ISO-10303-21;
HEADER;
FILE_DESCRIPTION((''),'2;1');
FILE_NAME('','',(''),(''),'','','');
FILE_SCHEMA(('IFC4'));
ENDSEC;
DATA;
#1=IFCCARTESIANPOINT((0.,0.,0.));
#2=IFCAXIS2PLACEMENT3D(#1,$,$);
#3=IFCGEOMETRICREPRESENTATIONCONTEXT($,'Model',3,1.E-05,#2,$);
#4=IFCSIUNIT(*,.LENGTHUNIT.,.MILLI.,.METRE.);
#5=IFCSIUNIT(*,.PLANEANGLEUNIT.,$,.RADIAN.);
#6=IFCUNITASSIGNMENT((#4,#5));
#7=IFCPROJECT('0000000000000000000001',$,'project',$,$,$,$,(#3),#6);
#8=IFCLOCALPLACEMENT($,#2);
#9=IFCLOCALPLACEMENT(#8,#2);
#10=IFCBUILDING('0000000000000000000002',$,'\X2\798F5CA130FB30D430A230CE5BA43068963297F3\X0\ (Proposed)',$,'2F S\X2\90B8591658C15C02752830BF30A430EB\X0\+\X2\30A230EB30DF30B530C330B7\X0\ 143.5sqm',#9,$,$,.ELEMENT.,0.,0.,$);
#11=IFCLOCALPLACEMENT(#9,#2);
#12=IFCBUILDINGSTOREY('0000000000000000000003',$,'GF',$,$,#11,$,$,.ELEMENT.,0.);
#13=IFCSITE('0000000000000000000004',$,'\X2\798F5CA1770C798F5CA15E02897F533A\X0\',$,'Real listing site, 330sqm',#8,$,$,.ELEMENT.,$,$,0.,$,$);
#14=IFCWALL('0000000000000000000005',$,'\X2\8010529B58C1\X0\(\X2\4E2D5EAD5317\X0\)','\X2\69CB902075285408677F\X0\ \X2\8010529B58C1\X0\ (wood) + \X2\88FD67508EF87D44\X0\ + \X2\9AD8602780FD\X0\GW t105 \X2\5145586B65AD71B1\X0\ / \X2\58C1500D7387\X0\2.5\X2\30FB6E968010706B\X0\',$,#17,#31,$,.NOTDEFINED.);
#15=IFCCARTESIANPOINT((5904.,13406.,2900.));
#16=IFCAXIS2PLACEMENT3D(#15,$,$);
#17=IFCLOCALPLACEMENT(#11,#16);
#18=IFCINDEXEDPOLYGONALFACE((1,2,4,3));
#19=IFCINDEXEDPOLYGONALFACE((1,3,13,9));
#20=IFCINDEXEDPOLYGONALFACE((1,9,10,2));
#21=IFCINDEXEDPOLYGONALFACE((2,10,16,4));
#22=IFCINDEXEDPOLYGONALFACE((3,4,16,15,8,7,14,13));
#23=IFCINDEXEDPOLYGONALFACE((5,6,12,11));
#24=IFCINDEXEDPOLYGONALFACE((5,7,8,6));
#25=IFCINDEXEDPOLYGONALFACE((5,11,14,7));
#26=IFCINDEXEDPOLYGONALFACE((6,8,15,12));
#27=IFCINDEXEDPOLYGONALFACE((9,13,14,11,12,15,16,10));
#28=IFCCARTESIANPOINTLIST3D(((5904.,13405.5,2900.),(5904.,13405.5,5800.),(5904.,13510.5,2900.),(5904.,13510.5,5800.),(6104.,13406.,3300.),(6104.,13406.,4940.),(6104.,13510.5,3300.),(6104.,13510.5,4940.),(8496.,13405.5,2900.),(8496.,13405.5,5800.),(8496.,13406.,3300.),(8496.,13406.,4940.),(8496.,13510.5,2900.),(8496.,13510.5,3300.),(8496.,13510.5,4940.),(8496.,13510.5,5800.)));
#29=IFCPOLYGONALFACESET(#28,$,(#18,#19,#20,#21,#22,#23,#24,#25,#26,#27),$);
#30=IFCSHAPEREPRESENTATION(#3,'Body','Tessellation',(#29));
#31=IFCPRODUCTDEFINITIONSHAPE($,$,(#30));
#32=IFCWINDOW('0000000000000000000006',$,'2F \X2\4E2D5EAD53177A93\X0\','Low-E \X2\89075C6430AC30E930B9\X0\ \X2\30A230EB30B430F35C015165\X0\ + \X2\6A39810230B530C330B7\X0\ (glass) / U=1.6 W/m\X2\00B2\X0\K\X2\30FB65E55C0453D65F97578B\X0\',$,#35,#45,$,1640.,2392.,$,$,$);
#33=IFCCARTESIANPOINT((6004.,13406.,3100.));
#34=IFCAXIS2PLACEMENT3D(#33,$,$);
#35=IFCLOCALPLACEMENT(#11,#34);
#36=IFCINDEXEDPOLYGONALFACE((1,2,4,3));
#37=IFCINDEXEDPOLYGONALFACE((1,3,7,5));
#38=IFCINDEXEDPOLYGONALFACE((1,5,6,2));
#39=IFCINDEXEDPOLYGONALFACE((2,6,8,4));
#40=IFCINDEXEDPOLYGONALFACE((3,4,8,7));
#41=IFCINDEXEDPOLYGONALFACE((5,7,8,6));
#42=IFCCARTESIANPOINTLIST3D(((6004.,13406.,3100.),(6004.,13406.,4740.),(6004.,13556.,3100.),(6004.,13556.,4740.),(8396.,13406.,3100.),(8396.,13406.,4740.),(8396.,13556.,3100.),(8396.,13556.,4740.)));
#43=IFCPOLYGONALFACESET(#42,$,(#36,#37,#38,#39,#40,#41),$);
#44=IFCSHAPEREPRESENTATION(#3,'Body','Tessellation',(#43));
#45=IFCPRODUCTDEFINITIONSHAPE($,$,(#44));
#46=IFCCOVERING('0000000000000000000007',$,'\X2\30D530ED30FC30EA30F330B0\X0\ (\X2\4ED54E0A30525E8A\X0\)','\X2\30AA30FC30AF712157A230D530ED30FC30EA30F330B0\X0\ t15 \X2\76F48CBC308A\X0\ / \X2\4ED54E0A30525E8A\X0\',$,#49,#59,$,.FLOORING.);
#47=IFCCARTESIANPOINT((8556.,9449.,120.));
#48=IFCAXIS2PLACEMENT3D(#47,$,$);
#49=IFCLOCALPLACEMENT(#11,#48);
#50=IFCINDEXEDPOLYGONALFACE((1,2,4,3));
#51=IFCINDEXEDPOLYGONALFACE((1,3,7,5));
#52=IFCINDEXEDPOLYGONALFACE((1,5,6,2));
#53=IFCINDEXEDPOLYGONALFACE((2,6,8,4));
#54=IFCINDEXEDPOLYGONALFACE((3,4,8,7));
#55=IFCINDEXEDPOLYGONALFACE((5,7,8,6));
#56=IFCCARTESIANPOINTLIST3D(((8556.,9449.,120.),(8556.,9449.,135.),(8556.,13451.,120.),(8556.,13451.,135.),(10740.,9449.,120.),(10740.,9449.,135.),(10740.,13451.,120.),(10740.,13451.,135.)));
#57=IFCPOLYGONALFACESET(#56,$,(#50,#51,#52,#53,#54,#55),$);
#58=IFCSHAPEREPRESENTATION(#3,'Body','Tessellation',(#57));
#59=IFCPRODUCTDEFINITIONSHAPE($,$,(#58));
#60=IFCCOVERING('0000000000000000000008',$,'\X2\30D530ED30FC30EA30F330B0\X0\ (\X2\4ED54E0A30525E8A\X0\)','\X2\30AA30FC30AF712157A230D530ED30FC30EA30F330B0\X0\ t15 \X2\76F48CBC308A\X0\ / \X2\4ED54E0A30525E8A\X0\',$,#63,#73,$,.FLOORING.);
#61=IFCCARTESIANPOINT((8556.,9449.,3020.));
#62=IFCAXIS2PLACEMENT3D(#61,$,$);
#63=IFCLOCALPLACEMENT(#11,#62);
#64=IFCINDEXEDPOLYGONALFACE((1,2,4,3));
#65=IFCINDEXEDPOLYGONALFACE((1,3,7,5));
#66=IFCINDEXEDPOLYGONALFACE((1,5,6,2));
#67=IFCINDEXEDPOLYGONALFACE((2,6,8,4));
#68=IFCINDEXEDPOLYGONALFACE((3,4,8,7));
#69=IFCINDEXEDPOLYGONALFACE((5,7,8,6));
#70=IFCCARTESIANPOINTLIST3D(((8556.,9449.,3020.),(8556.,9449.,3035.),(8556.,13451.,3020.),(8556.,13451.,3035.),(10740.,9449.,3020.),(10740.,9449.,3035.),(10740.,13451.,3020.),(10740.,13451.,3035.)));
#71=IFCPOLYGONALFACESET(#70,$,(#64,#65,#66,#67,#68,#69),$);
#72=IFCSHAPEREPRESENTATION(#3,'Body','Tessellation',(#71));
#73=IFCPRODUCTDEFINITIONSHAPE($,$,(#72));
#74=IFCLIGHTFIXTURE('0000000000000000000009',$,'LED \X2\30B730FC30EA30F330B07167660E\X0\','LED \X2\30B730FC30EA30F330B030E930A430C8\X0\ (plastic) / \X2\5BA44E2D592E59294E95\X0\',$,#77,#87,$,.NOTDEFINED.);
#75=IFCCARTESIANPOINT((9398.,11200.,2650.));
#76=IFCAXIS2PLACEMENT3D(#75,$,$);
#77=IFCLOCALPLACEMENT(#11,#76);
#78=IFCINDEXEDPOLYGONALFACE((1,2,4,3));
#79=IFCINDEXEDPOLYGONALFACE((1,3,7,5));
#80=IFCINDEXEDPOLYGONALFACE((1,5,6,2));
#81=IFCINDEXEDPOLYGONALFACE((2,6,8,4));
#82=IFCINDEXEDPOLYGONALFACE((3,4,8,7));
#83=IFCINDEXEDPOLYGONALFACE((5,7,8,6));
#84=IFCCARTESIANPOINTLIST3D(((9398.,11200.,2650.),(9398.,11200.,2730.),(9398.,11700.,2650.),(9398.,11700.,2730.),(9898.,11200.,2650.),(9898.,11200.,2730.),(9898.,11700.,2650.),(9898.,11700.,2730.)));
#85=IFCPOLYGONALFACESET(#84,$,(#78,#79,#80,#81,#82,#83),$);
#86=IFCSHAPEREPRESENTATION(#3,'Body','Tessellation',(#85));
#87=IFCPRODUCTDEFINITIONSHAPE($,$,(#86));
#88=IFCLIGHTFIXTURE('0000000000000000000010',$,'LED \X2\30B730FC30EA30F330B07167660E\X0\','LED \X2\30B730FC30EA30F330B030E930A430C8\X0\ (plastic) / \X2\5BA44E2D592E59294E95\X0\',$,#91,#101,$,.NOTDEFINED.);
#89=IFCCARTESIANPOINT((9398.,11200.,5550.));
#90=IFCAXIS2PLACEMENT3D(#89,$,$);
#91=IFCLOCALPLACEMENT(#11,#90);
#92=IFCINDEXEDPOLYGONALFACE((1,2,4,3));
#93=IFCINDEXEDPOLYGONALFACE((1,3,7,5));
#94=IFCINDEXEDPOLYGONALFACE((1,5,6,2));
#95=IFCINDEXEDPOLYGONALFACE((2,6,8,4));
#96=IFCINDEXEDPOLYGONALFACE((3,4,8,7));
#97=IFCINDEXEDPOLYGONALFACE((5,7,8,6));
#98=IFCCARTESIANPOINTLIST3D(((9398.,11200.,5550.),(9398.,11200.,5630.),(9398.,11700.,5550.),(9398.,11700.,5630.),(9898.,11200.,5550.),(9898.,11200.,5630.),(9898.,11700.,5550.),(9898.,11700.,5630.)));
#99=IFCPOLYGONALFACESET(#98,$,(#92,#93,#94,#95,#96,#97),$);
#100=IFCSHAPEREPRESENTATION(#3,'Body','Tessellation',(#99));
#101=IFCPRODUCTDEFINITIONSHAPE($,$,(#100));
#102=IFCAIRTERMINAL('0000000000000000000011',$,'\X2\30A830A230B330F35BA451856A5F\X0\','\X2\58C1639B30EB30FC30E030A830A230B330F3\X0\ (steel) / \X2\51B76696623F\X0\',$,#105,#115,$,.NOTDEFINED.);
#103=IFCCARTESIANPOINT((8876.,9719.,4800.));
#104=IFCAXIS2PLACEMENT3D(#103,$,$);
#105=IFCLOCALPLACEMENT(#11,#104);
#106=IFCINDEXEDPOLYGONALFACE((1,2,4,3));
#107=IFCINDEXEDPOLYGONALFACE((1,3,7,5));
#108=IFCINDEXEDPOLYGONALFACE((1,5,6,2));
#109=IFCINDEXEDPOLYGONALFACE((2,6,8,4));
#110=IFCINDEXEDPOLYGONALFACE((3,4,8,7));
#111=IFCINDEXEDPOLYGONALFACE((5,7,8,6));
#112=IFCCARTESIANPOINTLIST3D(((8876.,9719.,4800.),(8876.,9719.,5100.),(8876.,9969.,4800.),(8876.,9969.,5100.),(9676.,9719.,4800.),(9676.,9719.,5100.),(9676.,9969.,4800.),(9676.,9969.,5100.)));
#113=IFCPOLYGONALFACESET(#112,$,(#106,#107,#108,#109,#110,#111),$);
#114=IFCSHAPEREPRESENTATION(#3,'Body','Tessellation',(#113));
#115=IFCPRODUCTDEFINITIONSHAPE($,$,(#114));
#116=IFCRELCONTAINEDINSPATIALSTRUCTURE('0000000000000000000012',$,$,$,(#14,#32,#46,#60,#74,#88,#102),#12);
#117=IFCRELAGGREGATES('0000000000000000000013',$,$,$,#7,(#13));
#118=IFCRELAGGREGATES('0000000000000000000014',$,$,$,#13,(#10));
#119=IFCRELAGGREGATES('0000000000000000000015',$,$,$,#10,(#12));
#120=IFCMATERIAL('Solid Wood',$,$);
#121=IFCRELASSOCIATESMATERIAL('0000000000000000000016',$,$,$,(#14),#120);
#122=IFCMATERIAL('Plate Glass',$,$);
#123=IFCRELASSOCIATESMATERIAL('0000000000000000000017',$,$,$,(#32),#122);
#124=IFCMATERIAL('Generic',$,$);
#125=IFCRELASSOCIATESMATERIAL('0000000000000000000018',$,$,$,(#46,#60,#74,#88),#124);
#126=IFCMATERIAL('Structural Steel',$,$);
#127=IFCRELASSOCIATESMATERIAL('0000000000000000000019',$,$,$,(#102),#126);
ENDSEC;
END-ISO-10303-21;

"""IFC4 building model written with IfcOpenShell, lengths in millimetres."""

from ifc_helpers import new_model, si_unit, frame, frame_2d, origin, place, context, project, spatial, rectangle, extrude, material, element, fill, save


model = new_model("IFC4")

# Units and contexts
model_context = context("Model", 3, precision=1e-05, world=origin())
ifc_project = project(units=[si_unit("LENGTHUNIT", "METRE", prefix="MILLI"), si_unit("PLANEANGLEUNIT", "RADIAN")], contexts=[model_context])

# Site, building, storey
site_placement = place(None, origin())
site = spatial("IfcSite", under=ifc_project, at=site_placement, Name="福岡県福岡市西区", ObjectType="Real listing site, 330sqm", CompositionType="ELEMENT", RefElevation=0.0)
building_placement = place(site_placement, origin())
building = spatial("IfcBuilding", under=site, at=building_placement, Name="福岡・ピアノ室と防音 (Proposed)", ObjectType="2F S邸外壁専用タイル+アルミサッシ 143.5sqm", CompositionType="ELEMENT", ElevationOfRefHeight=0.0, ElevationOfTerrain=0.0)
storey_placement = place(building_placement, origin())
storey = spatial("IfcBuildingStorey", under=building, at=storey_placement, Name="GF", CompositionType="ELEMENT", Elevation=0.0)

# Shared definitions
ifc_material_1 = material(Name="Solid Wood")

# Wall, opening, window
ifc_material_2 = material(Name="Plate Glass")
wall_1_placement = place(storey_placement, frame((5904.0, 13406.0, 2900.0)))
wall_1 = element("IfcWall", 1, at=wall_1_placement, inside=storey, material=ifc_material_1, Name="耐力壁(中庭北)", Description="構造用合板 耐力壁 (wood) + 製材軸組 + 高性能GW t105 充填断熱 / 壁倍率2.5・準耐火", PredefinedType="NOTDEFINED", context=model_context, shape_type="SweptSolid", body=[
    extrude(rectangle(XDim=2592.0, YDim=105.0, at=frame_2d((1296.0, 52.0))), frame((5904.0, 13406.0, 2900.0)), (0.0, 0.0, 1.0), 2900.0),
])
opening_1_placement = place(storey_placement, frame((6004.0, 13406.0, 3100.0)))
opening_1 = element("IfcOpeningElement", 2, at=opening_1_placement, cuts=wall_1, PredefinedType="NOTDEFINED", context=model_context, shape_type="SweptSolid", body=[
    extrude(rectangle(XDim=2392.0, YDim=150.0, at=frame_2d((1196.0, 75.0))), frame((6004.0, 13406.0, 3100.0)), (0.0, 0.0, 1.0), 1640.0),
])
window_1_placement = place(storey_placement, frame((6004.0, 13406.0, 3100.0)))
window_1 = element("IfcWindow", 3, at=window_1_placement, inside=storey, material=ifc_material_2, Name="2F 中庭北窓", Description="Low-E 複層ガラス アルゴン封入 + 樹脂サッシ (glass) / U=1.6 W/m²K・日射取得型", OverallHeight=1640.0, OverallWidth=2392.0, context=model_context, shape_type="SweptSolid", body=[
    extrude(rectangle(XDim=2392.0, YDim=150.0, at=frame_2d((1196.0, 75.0))), frame((6004.0, 13406.0, 3100.0)), (0.0, 0.0, 1.0), 1640.0),
])
fill(opening_1, window_1)

# Coverings
ifc_material_3 = material(Name="Generic")
covering_1_placement = place(storey_placement, frame((8556.0, 9449.0, 120.0)))
element("IfcCovering", 4, at=covering_1_placement, inside=storey, material=ifc_material_3, Name="フローリング (仕上げ床)", Description="オーク無垢フローリング t15 直貼り / 仕上げ床", PredefinedType="FLOORING", context=model_context, shape_type="SweptSolid", body=[
    extrude(rectangle(XDim=2184.0, YDim=4002.0, at=frame_2d((1092.0, 2001.0))), frame((8556.0, 9449.0, 120.0)), (0.0, 0.0, 1.0), 15.0),
])
covering_2_placement = place(storey_placement, frame((8556.0, 9449.0, 3020.0)))
element("IfcCovering", 5, at=covering_2_placement, inside=storey, material=ifc_material_3, Name="フローリング (仕上げ床)", Description="オーク無垢フローリング t15 直貼り / 仕上げ床", PredefinedType="FLOORING", context=model_context, shape_type="SweptSolid", body=[
    extrude(rectangle(XDim=2184.0, YDim=4002.0, at=frame_2d((1092.0, 2001.0))), frame((8556.0, 9449.0, 3020.0)), (0.0, 0.0, 1.0), 15.0),
])

# Light fixtures
light_fixture_1_placement = place(storey_placement, frame((9398.0, 11200.0, 2650.0)))
element("IfcLightFixture", 6, at=light_fixture_1_placement, inside=storey, material=ifc_material_3, Name="LED シーリング照明", Description="LED シーリングライト (plastic) / 室中央天井", PredefinedType="NOTDEFINED", context=model_context, shape_type="SweptSolid", body=[
    extrude(rectangle(XDim=500.0, YDim=500.0, at=frame_2d((250.0, 250.0))), frame((9398.0, 11200.0, 2650.0)), (0.0, 0.0, 1.0), 80.0),
])
light_fixture_2_placement = place(storey_placement, frame((9398.0, 11200.0, 5550.0)))
element("IfcLightFixture", 7, at=light_fixture_2_placement, inside=storey, material=ifc_material_3, Name="LED シーリング照明", Description="LED シーリングライト (plastic) / 室中央天井", PredefinedType="NOTDEFINED", context=model_context, shape_type="SweptSolid", body=[
    extrude(rectangle(XDim=500.0, YDim=500.0, at=frame_2d((250.0, 250.0))), frame((9398.0, 11200.0, 5550.0)), (0.0, 0.0, 1.0), 80.0),
])

# Air terminal
ifc_material_4 = material(Name="Structural Steel")
air_terminal_placement = place(storey_placement, frame((8876.0, 9719.0, 4800.0)))
element("IfcAirTerminal", 8, at=air_terminal_placement, inside=storey, material=ifc_material_4, Name="エアコン室内機", Description="壁掛ルームエアコン (steel) / 冷暖房", PredefinedType="NOTDEFINED", context=model_context, shape_type="SweptSolid", body=[
    extrude(rectangle(XDim=800.0, YDim=250.0, at=frame_2d((400.0, 125.0))), frame((8876.0, 9719.0, 4800.0)), (0.0, 0.0, 1.0), 300.0),
])

save(model, "model.ifc")
